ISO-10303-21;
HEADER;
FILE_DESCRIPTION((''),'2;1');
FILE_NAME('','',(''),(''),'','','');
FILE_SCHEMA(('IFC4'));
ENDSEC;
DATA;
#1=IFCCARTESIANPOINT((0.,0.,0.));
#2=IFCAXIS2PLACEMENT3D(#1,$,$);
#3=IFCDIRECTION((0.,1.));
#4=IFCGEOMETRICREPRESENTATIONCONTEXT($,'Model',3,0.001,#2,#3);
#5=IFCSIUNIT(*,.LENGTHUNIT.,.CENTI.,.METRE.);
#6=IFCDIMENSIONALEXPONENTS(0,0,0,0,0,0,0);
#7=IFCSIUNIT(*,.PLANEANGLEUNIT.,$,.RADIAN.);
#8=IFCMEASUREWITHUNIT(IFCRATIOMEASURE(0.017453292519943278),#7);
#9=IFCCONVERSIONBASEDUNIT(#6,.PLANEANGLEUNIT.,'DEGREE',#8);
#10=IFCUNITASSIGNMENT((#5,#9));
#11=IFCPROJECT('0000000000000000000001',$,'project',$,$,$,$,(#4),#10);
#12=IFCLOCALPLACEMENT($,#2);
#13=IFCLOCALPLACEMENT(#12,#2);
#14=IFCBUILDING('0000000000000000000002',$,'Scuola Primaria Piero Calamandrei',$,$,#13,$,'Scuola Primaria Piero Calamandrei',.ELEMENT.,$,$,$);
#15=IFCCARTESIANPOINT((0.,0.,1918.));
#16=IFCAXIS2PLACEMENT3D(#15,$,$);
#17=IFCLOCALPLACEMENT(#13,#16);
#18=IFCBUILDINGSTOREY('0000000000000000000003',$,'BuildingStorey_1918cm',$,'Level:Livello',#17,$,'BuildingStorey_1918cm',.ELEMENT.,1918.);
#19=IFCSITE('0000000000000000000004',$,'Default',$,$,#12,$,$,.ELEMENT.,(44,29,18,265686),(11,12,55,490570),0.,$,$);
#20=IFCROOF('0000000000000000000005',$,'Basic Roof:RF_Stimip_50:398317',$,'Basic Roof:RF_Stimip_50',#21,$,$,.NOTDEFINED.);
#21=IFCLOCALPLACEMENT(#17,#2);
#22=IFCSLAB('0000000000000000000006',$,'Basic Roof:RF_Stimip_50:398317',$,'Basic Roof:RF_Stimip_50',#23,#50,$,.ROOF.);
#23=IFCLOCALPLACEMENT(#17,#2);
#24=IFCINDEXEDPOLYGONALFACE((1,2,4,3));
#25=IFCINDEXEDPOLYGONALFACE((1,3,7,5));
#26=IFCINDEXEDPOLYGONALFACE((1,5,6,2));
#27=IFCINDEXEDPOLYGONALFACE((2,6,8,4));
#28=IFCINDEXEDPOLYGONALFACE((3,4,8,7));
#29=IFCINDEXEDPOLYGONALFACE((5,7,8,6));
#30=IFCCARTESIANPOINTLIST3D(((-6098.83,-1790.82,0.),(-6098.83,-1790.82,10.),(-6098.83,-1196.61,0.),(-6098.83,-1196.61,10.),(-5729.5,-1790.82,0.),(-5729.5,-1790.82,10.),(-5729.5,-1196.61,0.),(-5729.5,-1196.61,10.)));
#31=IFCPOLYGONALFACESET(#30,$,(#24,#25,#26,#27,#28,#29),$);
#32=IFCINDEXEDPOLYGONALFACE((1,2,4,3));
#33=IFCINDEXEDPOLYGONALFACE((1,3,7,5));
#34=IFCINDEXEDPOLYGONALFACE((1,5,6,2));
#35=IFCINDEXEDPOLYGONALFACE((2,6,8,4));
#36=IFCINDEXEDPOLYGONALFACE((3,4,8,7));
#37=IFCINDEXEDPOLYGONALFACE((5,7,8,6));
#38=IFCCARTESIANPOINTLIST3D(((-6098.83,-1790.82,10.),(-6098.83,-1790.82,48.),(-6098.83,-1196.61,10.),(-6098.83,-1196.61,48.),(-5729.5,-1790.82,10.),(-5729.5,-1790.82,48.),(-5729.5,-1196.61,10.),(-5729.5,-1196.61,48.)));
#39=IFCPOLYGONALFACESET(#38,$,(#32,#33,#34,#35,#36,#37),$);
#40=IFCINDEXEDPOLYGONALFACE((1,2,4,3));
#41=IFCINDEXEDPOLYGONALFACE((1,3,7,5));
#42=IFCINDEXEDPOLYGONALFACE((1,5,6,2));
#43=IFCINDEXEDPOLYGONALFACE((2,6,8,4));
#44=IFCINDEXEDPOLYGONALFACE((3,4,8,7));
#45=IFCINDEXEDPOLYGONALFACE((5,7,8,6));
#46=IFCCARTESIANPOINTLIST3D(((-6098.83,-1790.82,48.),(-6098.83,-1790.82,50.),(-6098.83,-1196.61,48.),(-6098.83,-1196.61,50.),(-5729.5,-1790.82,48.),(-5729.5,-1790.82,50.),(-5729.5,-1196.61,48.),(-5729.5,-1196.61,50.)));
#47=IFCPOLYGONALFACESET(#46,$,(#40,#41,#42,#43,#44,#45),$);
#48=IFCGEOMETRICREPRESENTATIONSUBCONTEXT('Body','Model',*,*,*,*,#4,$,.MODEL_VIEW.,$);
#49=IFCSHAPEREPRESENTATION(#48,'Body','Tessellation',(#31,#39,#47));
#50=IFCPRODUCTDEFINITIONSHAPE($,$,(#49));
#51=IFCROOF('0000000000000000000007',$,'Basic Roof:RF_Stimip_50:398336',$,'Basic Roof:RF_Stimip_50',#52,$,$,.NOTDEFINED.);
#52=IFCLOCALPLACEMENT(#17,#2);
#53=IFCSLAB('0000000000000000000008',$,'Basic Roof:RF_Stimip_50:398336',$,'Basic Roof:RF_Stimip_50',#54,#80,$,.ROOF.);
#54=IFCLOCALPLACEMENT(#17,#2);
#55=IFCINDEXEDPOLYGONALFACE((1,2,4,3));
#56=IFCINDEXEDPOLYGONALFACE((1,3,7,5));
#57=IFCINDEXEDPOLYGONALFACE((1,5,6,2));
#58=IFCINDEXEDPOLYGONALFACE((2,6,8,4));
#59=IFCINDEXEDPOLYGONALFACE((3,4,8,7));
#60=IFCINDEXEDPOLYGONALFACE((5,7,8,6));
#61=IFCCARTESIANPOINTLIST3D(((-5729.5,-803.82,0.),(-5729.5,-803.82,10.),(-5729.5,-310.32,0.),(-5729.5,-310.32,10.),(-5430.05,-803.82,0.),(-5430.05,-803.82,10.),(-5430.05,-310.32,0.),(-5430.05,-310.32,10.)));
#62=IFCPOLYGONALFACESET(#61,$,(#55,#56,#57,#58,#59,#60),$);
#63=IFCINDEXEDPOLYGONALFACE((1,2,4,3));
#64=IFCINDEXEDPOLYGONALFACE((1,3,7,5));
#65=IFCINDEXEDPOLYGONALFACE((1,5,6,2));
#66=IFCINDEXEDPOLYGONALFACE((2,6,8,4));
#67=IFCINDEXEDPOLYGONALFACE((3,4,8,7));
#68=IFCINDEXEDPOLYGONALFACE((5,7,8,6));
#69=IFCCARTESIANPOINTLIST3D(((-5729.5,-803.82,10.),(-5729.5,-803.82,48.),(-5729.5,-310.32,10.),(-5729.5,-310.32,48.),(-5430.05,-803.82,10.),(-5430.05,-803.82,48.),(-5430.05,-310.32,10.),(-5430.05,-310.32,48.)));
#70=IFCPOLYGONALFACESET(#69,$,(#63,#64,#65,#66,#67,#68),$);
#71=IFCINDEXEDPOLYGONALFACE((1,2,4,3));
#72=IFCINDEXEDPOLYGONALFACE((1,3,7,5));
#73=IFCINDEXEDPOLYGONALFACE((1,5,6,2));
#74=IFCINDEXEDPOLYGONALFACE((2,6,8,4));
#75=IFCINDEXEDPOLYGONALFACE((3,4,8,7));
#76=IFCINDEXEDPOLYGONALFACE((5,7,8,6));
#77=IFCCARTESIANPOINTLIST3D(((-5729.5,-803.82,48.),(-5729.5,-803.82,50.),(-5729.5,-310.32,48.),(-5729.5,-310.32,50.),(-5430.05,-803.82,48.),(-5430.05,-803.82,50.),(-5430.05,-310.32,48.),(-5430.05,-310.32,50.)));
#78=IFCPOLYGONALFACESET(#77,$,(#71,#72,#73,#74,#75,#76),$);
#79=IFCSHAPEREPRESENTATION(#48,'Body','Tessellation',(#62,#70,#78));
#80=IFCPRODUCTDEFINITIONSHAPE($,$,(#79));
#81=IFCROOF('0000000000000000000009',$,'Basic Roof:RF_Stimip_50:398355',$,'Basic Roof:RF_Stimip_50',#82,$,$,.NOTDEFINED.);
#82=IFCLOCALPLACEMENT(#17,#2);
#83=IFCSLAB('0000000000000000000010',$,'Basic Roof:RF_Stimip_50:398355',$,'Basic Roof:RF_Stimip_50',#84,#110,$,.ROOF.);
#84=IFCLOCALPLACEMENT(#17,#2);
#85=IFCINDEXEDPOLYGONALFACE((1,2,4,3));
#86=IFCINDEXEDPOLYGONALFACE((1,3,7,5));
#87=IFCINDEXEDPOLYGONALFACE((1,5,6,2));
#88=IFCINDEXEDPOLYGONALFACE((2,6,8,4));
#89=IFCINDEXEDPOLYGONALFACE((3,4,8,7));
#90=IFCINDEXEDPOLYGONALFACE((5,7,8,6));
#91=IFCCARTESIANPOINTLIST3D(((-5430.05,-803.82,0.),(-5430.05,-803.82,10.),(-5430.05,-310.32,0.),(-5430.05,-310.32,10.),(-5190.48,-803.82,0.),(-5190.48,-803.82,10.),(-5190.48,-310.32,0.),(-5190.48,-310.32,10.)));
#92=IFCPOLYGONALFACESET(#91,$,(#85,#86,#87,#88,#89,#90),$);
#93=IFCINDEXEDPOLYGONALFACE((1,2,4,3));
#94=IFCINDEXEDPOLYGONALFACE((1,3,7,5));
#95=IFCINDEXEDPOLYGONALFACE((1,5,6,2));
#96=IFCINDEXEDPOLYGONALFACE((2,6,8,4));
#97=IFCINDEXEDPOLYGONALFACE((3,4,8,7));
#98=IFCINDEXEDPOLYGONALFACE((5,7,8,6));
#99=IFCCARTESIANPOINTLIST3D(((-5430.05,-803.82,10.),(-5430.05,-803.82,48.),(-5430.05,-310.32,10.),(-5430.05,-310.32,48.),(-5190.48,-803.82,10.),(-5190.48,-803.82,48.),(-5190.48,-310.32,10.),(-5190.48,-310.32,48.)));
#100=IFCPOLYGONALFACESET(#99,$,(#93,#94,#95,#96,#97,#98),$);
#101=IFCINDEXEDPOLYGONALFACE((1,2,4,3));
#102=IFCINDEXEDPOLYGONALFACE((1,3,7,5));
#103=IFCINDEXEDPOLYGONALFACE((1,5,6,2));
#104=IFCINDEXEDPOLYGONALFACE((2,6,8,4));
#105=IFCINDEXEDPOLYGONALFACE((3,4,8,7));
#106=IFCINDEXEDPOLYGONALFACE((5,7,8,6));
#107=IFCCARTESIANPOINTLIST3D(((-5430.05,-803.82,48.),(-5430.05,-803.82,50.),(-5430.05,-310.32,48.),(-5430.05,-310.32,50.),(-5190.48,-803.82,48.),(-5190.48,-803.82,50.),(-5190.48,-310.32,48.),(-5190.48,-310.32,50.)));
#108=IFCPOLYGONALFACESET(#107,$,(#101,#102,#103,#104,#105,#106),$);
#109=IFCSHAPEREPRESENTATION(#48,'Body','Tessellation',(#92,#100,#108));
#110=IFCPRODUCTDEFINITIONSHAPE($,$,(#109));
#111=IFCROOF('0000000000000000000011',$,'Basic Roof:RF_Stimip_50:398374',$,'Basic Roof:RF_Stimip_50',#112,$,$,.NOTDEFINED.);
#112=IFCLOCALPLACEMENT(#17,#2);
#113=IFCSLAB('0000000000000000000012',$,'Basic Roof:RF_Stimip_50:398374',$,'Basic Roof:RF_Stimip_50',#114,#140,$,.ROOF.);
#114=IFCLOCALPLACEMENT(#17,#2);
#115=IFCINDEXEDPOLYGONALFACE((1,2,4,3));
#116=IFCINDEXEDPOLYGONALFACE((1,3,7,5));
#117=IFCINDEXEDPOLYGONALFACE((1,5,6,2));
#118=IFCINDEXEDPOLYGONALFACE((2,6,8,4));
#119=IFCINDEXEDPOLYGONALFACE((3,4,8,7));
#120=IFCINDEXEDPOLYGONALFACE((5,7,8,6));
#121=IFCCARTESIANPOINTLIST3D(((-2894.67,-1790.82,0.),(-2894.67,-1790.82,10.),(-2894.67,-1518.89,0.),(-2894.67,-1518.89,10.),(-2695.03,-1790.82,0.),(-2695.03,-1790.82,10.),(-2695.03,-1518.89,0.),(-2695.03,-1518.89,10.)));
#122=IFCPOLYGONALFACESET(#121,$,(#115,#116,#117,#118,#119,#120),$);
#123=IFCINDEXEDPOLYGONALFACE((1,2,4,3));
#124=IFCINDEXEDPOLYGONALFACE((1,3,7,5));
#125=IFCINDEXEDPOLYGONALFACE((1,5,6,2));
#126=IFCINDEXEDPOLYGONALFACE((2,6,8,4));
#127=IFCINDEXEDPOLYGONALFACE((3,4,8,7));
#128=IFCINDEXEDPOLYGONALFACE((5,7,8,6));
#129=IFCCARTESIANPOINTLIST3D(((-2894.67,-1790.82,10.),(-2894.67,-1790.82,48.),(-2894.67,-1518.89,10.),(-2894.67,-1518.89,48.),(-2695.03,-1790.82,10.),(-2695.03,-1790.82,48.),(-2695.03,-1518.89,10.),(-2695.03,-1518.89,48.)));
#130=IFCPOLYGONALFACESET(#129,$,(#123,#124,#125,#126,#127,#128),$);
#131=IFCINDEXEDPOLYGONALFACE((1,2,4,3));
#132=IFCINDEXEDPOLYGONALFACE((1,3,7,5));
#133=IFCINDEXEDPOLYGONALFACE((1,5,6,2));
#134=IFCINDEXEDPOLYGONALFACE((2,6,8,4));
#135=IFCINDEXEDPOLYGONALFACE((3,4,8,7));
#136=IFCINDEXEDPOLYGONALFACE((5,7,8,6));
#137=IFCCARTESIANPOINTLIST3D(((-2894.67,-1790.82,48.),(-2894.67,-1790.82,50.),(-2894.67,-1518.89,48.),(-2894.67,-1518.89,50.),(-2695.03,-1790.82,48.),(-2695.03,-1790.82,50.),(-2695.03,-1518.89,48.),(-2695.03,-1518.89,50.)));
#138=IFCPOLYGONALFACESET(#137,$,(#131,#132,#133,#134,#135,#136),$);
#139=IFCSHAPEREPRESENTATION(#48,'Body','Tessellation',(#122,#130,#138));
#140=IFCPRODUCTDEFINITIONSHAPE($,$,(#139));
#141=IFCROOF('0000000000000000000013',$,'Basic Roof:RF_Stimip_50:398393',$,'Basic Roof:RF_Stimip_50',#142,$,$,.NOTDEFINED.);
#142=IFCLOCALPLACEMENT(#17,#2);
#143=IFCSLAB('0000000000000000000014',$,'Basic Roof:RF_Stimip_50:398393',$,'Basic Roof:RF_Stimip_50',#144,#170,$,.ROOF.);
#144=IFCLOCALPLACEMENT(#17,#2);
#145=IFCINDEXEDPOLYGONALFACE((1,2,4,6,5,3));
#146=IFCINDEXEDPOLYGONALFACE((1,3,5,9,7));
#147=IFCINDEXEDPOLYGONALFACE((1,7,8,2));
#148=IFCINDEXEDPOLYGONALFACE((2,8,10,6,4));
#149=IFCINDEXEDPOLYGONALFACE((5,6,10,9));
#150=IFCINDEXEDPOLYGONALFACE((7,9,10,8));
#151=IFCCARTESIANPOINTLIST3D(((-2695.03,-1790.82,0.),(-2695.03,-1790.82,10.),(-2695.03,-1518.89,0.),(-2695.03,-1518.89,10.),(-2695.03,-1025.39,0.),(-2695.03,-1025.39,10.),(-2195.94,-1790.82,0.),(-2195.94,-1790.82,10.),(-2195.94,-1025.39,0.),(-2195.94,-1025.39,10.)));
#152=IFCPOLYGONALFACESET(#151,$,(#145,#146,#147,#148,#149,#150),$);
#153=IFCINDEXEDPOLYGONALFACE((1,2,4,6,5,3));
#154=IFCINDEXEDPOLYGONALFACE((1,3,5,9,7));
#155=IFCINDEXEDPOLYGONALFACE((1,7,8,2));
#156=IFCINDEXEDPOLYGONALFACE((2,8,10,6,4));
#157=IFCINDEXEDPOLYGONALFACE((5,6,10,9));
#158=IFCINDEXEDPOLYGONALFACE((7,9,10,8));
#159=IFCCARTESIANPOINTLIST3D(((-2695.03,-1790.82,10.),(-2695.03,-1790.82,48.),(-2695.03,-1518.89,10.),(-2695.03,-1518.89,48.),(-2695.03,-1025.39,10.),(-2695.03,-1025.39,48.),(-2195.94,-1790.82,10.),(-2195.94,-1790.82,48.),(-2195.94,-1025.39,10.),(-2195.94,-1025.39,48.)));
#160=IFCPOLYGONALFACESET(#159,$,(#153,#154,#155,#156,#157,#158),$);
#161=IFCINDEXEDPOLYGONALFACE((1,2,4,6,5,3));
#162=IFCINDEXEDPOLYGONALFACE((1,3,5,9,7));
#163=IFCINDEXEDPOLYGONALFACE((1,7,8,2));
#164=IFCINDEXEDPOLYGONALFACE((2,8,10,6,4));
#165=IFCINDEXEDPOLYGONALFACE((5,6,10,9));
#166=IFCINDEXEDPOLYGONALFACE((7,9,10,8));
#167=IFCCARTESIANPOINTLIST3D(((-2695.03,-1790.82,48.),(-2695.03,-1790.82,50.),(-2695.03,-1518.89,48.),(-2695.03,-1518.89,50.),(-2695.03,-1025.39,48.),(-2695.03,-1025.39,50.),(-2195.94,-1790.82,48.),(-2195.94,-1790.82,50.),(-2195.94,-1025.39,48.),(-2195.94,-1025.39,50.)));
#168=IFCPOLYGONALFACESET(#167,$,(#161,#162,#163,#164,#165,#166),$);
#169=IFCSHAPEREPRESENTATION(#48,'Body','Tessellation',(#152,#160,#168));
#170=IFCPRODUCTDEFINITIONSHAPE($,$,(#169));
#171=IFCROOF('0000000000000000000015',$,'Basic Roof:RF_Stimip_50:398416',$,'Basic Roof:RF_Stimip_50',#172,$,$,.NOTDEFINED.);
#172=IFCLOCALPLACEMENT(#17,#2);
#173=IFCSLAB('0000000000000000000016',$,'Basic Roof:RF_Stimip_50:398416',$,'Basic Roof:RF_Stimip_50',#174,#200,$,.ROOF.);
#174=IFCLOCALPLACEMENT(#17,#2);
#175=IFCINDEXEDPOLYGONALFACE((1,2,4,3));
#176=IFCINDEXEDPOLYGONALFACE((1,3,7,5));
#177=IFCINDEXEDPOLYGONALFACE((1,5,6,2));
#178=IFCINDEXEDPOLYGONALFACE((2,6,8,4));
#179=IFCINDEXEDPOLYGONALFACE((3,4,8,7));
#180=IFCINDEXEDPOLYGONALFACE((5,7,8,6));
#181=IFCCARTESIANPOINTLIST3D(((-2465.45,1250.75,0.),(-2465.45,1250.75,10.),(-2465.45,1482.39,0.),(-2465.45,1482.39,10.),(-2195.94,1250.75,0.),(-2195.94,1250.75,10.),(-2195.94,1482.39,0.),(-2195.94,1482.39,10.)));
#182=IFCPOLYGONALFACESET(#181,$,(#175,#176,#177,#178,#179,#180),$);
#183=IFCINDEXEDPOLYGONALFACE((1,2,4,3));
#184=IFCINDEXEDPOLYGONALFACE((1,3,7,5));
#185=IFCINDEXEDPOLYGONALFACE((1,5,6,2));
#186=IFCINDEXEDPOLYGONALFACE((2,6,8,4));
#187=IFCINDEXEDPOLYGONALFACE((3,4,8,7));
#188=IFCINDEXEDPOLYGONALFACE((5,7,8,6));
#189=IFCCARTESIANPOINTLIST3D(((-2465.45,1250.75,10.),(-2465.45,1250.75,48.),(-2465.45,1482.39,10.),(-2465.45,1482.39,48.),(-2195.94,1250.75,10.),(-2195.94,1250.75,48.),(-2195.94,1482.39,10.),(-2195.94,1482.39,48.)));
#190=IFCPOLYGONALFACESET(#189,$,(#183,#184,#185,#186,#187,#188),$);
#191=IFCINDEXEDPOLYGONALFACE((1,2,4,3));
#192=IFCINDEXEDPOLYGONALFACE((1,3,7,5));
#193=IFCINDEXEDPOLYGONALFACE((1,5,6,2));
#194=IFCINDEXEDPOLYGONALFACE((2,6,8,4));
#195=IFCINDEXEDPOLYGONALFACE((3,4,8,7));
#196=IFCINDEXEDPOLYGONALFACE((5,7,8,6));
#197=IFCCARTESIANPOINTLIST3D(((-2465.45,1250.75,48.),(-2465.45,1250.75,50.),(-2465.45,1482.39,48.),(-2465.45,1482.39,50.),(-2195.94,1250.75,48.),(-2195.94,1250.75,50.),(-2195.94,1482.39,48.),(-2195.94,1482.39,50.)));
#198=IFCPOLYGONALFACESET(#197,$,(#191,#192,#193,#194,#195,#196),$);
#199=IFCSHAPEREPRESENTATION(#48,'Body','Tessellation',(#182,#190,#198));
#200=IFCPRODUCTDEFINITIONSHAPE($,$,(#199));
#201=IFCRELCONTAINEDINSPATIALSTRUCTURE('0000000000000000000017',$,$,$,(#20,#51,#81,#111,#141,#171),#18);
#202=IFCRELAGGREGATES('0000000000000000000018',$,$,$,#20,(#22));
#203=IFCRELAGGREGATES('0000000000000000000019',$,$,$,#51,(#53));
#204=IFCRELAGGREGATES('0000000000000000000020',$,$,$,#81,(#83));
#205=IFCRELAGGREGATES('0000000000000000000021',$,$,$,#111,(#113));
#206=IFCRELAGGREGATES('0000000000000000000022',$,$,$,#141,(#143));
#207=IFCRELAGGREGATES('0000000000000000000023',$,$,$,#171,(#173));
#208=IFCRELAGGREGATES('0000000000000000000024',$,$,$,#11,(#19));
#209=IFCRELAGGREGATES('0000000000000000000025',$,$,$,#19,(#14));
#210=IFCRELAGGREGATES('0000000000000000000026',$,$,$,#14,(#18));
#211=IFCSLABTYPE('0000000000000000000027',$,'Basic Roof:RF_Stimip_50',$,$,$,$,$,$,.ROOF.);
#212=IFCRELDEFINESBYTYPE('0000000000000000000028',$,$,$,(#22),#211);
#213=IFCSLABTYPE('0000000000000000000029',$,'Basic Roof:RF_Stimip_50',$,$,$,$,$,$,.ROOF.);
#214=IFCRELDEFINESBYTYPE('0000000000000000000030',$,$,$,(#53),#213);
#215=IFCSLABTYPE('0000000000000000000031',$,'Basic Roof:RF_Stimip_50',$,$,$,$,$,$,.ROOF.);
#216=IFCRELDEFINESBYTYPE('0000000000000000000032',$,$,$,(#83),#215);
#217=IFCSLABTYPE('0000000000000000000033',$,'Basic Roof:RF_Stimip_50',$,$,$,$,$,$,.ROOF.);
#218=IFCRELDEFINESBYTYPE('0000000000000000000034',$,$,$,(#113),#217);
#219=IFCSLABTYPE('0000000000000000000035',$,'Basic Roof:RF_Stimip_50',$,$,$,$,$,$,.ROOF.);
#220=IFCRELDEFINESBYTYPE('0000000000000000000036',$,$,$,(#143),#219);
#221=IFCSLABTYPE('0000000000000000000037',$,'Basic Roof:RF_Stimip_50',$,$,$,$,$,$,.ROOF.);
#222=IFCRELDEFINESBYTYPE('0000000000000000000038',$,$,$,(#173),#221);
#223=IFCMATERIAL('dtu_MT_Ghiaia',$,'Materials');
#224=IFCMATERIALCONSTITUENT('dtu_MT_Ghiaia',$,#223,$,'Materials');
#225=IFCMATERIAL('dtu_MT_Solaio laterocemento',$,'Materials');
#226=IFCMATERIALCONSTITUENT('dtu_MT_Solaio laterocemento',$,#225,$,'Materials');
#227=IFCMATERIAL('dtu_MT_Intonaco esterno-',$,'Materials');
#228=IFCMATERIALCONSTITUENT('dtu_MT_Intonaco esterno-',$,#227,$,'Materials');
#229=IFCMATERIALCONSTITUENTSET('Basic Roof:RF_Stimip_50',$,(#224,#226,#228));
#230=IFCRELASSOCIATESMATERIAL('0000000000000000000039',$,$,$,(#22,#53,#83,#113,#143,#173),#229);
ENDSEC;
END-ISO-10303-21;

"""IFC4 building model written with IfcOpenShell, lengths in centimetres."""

from ifc_helpers import new_model, entity, si_unit, converted_unit, direction, frame, origin, place, context, subcontext, project, spatial, indexed_curve, outline, extrude, material, constituent, constituent_set, type_object, element, aggregate, save


model = new_model("IFC4")

# Units and contexts
model_context = context("Model", 3, precision=0.001, world=origin(), true_north=direction((0.0, 1.0)))
body_context = subcontext(model_context, "Body", "Model", "MODEL_VIEW")
ifc_project = project(units=[si_unit("LENGTHUNIT", "METRE", prefix="CENTI"), converted_unit("PLANEANGLEUNIT", "DEGREE", entity("IfcRatioMeasure", 0.017453292519943278), si_unit("PLANEANGLEUNIT", "RADIAN"), dimensions=[0, 0, 0, 0, 0, 0, 0])], contexts=[model_context])

# Site, building, storey
site_placement = place(None, origin())
site = spatial("IfcSite", under=ifc_project, at=site_placement, Name="Default", CompositionType="ELEMENT", RefLatitude=(44, 29, 18, 265686), RefLongitude=(11, 12, 55, 490570), RefElevation=0.0)
building_placement = place(site_placement, origin())
building = spatial("IfcBuilding", under=site, at=building_placement, Name="Scuola Primaria Piero Calamandrei", LongName="Scuola Primaria Piero Calamandrei", CompositionType="ELEMENT")
storey_placement = place(building_placement, frame((0.0, 0.0, 1918.0)))
storey = spatial("IfcBuildingStorey", under=building, at=storey_placement, Name="BuildingStorey_1918cm", ObjectType="Level:Livello", LongName="BuildingStorey_1918cm", CompositionType="ELEMENT", Elevation=1918.0)

# Roofs, slabs
ifc_material_1 = material(Name="dtu_MT_Ghiaia", Category="Materials")
ifc_constituent_1 = constituent(ifc_material_1, Name="dtu_MT_Ghiaia", Category="Materials")
ifc_material_2 = material(Name="dtu_MT_Solaio laterocemento", Category="Materials")
ifc_constituent_2 = constituent(ifc_material_2, Name="dtu_MT_Solaio laterocemento", Category="Materials")
ifc_material_3 = material(Name="dtu_MT_Intonaco esterno-", Category="Materials")
ifc_constituent_3 = constituent(ifc_material_3, Name="dtu_MT_Intonaco esterno-", Category="Materials")
ifc_constituent_set = constituent_set(constituents=[ifc_constituent_1, ifc_constituent_2, ifc_constituent_3], Name="Basic Roof:RF_Stimip_50")
roof_1_placement = place(storey_placement, frame((-6098.83, -1790.82, 0.0)))
roof_1 = element("IfcRoof", 1, at=roof_1_placement, inside=storey, Name="Basic Roof:RF_Stimip_50:398317", ObjectType="Basic Roof:RF_Stimip_50", PredefinedType="NOTDEFINED")
slab_type_1 = type_object("IfcSlabType", Name="Basic Roof:RF_Stimip_50", PredefinedType="ROOF")
slab_1_placement = place(roof_1_placement, origin())
slab_1 = element("IfcSlab", 2, at=slab_1_placement, type_object=slab_type_1, material=ifc_constituent_set, Name="Basic Roof:RF_Stimip_50:398317", ObjectType="Basic Roof:RF_Stimip_50", PredefinedType="ROOF", context=body_context, shape_type="SweptSolid", body=[
    extrude(outline(indexed_curve([(184.66, -297.11), (184.66, 297.11), (-184.66, 297.11), (-184.66, -297.11), (184.66, -297.11)], self_intersect=False)), frame((184.66, 297.11, 0.0)), (0.0, 0.0, 1.0), 10.0),
    extrude(outline(indexed_curve([(184.66, -297.11), (184.66, 297.11), (-184.66, 297.11), (-184.66, -297.11), (184.66, -297.11)], self_intersect=False)), frame((184.66, 297.11, 10.0)), (0.0, 0.0, 1.0), 38.0),
    extrude(outline(indexed_curve([(184.66, -297.11), (184.66, 297.11), (-184.66, 297.11), (-184.66, -297.11), (184.66, -297.11)], self_intersect=False)), frame((184.66, 297.11, 48.0)), (0.0, 0.0, 1.0), 2.0),
])
aggregate(roof_1, [slab_1])
roof_2_placement = place(storey_placement, frame((-5729.5, -803.82, 0.0)))
roof_2 = element("IfcRoof", 3, at=roof_2_placement, inside=storey, Name="Basic Roof:RF_Stimip_50:398336", ObjectType="Basic Roof:RF_Stimip_50", PredefinedType="NOTDEFINED")
slab_type_2 = type_object("IfcSlabType", Name="Basic Roof:RF_Stimip_50", PredefinedType="ROOF")
slab_2_placement = place(roof_2_placement, origin())
slab_2 = element("IfcSlab", 4, at=slab_2_placement, type_object=slab_type_2, material=ifc_constituent_set, Name="Basic Roof:RF_Stimip_50:398336", ObjectType="Basic Roof:RF_Stimip_50", PredefinedType="ROOF", context=body_context, shape_type="SweptSolid", body=[
    extrude(outline(indexed_curve([(149.73, 246.75), (-149.73, 246.75), (-149.73, -246.75), (149.73, -246.75), (149.73, 246.75)], self_intersect=False)), frame((149.73, 246.75, 0.0)), (0.0, 0.0, 1.0), 10.0),
    extrude(outline(indexed_curve([(149.73, 246.75), (-149.73, 246.75), (-149.73, -246.75), (149.73, -246.75), (149.73, 246.75)], self_intersect=False)), frame((149.73, 246.75, 10.0)), (0.0, 0.0, 1.0), 38.0),
    extrude(outline(indexed_curve([(149.73, 246.75), (-149.73, 246.75), (-149.73, -246.75), (149.73, -246.75), (149.73, 246.75)], self_intersect=False)), frame((149.73, 246.75, 48.0)), (0.0, 0.0, 1.0), 2.0),
])
aggregate(roof_2, [slab_2])
roof_3_placement = place(storey_placement, frame((-5430.05, -803.82, 0.0)))
roof_3 = element("IfcRoof", 5, at=roof_3_placement, inside=storey, Name="Basic Roof:RF_Stimip_50:398355", ObjectType="Basic Roof:RF_Stimip_50", PredefinedType="NOTDEFINED")
slab_type_3 = type_object("IfcSlabType", Name="Basic Roof:RF_Stimip_50", PredefinedType="ROOF")
slab_3_placement = place(roof_3_placement, origin())
slab_3 = element("IfcSlab", 6, at=slab_3_placement, type_object=slab_type_3, material=ifc_constituent_set, Name="Basic Roof:RF_Stimip_50:398355", ObjectType="Basic Roof:RF_Stimip_50", PredefinedType="ROOF", context=body_context, shape_type="SweptSolid", body=[
    extrude(outline(indexed_curve([(-119.78, 246.75), (-119.78, -246.75), (119.78, -246.75), (119.78, 246.75), (-119.78, 246.75)], self_intersect=False)), frame((119.78, 246.75, 0.0)), (0.0, 0.0, 1.0), 10.0),
    extrude(outline(indexed_curve([(-119.78, 246.75), (-119.78, -246.75), (119.78, -246.75), (119.78, 246.75), (-119.78, 246.75)], self_intersect=False)), frame((119.78, 246.75, 10.0)), (0.0, 0.0, 1.0), 38.0),
    extrude(outline(indexed_curve([(-119.78, 246.75), (-119.78, -246.75), (119.78, -246.75), (119.78, 246.75), (-119.78, 246.75)], self_intersect=False)), frame((119.78, 246.75, 48.0)), (0.0, 0.0, 1.0), 2.0),
])
aggregate(roof_3, [slab_3])
roof_4_placement = place(storey_placement, frame((-2894.67, -1790.82, 0.0)))
roof_4 = element("IfcRoof", 7, at=roof_4_placement, inside=storey, Name="Basic Roof:RF_Stimip_50:398374", ObjectType="Basic Roof:RF_Stimip_50", PredefinedType="NOTDEFINED")
slab_type_4 = type_object("IfcSlabType", Name="Basic Roof:RF_Stimip_50", PredefinedType="ROOF")
slab_4_placement = place(roof_4_placement, origin())
slab_4 = element("IfcSlab", 8, at=slab_4_placement, type_object=slab_type_4, material=ifc_constituent_set, Name="Basic Roof:RF_Stimip_50:398374", ObjectType="Basic Roof:RF_Stimip_50", PredefinedType="ROOF", context=body_context, shape_type="SweptSolid", body=[
    extrude(outline(indexed_curve([(99.82, -135.96), (99.82, 135.96), (-99.82, 135.96), (-99.82, -135.96), (99.82, -135.96)], self_intersect=False)), frame((99.82, 135.96, 0.0)), (0.0, 0.0, 1.0), 10.0),
    extrude(outline(indexed_curve([(99.82, -135.96), (99.82, 135.96), (-99.82, 135.96), (-99.82, -135.96), (99.82, -135.96)], self_intersect=False)), frame((99.82, 135.96, 10.0)), (0.0, 0.0, 1.0), 38.0),
    extrude(outline(indexed_curve([(99.82, -135.96), (99.82, 135.96), (-99.82, 135.96), (-99.82, -135.96), (99.82, -135.96)], self_intersect=False)), frame((99.82, 135.96, 48.0)), (0.0, 0.0, 1.0), 2.0),
])
aggregate(roof_4, [slab_4])
roof_5_placement = place(storey_placement, frame((-2695.03, -1790.82, 0.0)))
roof_5 = element("IfcRoof", 9, at=roof_5_placement, inside=storey, Name="Basic Roof:RF_Stimip_50:398393", ObjectType="Basic Roof:RF_Stimip_50", PredefinedType="NOTDEFINED")
slab_type_5 = type_object("IfcSlabType", Name="Basic Roof:RF_Stimip_50", PredefinedType="ROOF")
slab_5_placement = place(roof_5_placement, origin())
slab_5 = element("IfcSlab", 10, at=slab_5_placement, type_object=slab_type_5, material=ifc_constituent_set, Name="Basic Roof:RF_Stimip_50:398393", ObjectType="Basic Roof:RF_Stimip_50", PredefinedType="ROOF", context=body_context, shape_type="SweptSolid", body=[
    extrude(outline(indexed_curve([(-249.55, -382.71), (249.55, -382.71), (249.55, 382.71), (-249.55, 382.71), (-249.55, -110.79), (-249.55, -382.71)], self_intersect=False)), frame((249.55, 382.71, 0.0)), (0.0, 0.0, 1.0), 10.0),
    extrude(outline(indexed_curve([(-249.55, -382.71), (249.55, -382.71), (249.55, 382.71), (-249.55, 382.71), (-249.55, -110.79), (-249.55, -382.71)], self_intersect=False)), frame((249.55, 382.71, 10.0)), (0.0, 0.0, 1.0), 38.0),
    extrude(outline(indexed_curve([(-249.55, -382.71), (249.55, -382.71), (249.55, 382.71), (-249.55, 382.71), (-249.55, -110.79), (-249.55, -382.71)], self_intersect=False)), frame((249.55, 382.71, 48.0)), (0.0, 0.0, 1.0), 2.0),
])
aggregate(roof_5, [slab_5])
roof_6_placement = place(storey_placement, frame((-2465.45, 1250.75, 0.0)))
roof_6 = element("IfcRoof", 11, at=roof_6_placement, inside=storey, Name="Basic Roof:RF_Stimip_50:398416", ObjectType="Basic Roof:RF_Stimip_50", PredefinedType="NOTDEFINED")
slab_type_6 = type_object("IfcSlabType", Name="Basic Roof:RF_Stimip_50", PredefinedType="ROOF")
slab_6_placement = place(roof_6_placement, origin())
slab_6 = element("IfcSlab", 12, at=slab_6_placement, type_object=slab_type_6, material=ifc_constituent_set, Name="Basic Roof:RF_Stimip_50:398416", ObjectType="Basic Roof:RF_Stimip_50", PredefinedType="ROOF", context=body_context, shape_type="SweptSolid", body=[
    extrude(outline(indexed_curve([(134.75, 115.82), (-134.75, 115.82), (-134.75, -115.82), (134.75, -115.82), (134.75, 115.82)], self_intersect=False)), frame((134.75, 115.82, 0.0)), (0.0, 0.0, 1.0), 10.0),
    extrude(outline(indexed_curve([(134.75, 115.82), (-134.75, 115.82), (-134.75, -115.82), (134.75, -115.82), (134.75, 115.82)], self_intersect=False)), frame((134.75, 115.82, 10.0)), (0.0, 0.0, 1.0), 38.0),
    extrude(outline(indexed_curve([(134.75, 115.82), (-134.75, 115.82), (-134.75, -115.82), (134.75, -115.82), (134.75, 115.82)], self_intersect=False)), frame((134.75, 115.82, 48.0)), (0.0, 0.0, 1.0), 2.0),
])
aggregate(roof_6, [slab_6])

save(model, "model.ifc")
